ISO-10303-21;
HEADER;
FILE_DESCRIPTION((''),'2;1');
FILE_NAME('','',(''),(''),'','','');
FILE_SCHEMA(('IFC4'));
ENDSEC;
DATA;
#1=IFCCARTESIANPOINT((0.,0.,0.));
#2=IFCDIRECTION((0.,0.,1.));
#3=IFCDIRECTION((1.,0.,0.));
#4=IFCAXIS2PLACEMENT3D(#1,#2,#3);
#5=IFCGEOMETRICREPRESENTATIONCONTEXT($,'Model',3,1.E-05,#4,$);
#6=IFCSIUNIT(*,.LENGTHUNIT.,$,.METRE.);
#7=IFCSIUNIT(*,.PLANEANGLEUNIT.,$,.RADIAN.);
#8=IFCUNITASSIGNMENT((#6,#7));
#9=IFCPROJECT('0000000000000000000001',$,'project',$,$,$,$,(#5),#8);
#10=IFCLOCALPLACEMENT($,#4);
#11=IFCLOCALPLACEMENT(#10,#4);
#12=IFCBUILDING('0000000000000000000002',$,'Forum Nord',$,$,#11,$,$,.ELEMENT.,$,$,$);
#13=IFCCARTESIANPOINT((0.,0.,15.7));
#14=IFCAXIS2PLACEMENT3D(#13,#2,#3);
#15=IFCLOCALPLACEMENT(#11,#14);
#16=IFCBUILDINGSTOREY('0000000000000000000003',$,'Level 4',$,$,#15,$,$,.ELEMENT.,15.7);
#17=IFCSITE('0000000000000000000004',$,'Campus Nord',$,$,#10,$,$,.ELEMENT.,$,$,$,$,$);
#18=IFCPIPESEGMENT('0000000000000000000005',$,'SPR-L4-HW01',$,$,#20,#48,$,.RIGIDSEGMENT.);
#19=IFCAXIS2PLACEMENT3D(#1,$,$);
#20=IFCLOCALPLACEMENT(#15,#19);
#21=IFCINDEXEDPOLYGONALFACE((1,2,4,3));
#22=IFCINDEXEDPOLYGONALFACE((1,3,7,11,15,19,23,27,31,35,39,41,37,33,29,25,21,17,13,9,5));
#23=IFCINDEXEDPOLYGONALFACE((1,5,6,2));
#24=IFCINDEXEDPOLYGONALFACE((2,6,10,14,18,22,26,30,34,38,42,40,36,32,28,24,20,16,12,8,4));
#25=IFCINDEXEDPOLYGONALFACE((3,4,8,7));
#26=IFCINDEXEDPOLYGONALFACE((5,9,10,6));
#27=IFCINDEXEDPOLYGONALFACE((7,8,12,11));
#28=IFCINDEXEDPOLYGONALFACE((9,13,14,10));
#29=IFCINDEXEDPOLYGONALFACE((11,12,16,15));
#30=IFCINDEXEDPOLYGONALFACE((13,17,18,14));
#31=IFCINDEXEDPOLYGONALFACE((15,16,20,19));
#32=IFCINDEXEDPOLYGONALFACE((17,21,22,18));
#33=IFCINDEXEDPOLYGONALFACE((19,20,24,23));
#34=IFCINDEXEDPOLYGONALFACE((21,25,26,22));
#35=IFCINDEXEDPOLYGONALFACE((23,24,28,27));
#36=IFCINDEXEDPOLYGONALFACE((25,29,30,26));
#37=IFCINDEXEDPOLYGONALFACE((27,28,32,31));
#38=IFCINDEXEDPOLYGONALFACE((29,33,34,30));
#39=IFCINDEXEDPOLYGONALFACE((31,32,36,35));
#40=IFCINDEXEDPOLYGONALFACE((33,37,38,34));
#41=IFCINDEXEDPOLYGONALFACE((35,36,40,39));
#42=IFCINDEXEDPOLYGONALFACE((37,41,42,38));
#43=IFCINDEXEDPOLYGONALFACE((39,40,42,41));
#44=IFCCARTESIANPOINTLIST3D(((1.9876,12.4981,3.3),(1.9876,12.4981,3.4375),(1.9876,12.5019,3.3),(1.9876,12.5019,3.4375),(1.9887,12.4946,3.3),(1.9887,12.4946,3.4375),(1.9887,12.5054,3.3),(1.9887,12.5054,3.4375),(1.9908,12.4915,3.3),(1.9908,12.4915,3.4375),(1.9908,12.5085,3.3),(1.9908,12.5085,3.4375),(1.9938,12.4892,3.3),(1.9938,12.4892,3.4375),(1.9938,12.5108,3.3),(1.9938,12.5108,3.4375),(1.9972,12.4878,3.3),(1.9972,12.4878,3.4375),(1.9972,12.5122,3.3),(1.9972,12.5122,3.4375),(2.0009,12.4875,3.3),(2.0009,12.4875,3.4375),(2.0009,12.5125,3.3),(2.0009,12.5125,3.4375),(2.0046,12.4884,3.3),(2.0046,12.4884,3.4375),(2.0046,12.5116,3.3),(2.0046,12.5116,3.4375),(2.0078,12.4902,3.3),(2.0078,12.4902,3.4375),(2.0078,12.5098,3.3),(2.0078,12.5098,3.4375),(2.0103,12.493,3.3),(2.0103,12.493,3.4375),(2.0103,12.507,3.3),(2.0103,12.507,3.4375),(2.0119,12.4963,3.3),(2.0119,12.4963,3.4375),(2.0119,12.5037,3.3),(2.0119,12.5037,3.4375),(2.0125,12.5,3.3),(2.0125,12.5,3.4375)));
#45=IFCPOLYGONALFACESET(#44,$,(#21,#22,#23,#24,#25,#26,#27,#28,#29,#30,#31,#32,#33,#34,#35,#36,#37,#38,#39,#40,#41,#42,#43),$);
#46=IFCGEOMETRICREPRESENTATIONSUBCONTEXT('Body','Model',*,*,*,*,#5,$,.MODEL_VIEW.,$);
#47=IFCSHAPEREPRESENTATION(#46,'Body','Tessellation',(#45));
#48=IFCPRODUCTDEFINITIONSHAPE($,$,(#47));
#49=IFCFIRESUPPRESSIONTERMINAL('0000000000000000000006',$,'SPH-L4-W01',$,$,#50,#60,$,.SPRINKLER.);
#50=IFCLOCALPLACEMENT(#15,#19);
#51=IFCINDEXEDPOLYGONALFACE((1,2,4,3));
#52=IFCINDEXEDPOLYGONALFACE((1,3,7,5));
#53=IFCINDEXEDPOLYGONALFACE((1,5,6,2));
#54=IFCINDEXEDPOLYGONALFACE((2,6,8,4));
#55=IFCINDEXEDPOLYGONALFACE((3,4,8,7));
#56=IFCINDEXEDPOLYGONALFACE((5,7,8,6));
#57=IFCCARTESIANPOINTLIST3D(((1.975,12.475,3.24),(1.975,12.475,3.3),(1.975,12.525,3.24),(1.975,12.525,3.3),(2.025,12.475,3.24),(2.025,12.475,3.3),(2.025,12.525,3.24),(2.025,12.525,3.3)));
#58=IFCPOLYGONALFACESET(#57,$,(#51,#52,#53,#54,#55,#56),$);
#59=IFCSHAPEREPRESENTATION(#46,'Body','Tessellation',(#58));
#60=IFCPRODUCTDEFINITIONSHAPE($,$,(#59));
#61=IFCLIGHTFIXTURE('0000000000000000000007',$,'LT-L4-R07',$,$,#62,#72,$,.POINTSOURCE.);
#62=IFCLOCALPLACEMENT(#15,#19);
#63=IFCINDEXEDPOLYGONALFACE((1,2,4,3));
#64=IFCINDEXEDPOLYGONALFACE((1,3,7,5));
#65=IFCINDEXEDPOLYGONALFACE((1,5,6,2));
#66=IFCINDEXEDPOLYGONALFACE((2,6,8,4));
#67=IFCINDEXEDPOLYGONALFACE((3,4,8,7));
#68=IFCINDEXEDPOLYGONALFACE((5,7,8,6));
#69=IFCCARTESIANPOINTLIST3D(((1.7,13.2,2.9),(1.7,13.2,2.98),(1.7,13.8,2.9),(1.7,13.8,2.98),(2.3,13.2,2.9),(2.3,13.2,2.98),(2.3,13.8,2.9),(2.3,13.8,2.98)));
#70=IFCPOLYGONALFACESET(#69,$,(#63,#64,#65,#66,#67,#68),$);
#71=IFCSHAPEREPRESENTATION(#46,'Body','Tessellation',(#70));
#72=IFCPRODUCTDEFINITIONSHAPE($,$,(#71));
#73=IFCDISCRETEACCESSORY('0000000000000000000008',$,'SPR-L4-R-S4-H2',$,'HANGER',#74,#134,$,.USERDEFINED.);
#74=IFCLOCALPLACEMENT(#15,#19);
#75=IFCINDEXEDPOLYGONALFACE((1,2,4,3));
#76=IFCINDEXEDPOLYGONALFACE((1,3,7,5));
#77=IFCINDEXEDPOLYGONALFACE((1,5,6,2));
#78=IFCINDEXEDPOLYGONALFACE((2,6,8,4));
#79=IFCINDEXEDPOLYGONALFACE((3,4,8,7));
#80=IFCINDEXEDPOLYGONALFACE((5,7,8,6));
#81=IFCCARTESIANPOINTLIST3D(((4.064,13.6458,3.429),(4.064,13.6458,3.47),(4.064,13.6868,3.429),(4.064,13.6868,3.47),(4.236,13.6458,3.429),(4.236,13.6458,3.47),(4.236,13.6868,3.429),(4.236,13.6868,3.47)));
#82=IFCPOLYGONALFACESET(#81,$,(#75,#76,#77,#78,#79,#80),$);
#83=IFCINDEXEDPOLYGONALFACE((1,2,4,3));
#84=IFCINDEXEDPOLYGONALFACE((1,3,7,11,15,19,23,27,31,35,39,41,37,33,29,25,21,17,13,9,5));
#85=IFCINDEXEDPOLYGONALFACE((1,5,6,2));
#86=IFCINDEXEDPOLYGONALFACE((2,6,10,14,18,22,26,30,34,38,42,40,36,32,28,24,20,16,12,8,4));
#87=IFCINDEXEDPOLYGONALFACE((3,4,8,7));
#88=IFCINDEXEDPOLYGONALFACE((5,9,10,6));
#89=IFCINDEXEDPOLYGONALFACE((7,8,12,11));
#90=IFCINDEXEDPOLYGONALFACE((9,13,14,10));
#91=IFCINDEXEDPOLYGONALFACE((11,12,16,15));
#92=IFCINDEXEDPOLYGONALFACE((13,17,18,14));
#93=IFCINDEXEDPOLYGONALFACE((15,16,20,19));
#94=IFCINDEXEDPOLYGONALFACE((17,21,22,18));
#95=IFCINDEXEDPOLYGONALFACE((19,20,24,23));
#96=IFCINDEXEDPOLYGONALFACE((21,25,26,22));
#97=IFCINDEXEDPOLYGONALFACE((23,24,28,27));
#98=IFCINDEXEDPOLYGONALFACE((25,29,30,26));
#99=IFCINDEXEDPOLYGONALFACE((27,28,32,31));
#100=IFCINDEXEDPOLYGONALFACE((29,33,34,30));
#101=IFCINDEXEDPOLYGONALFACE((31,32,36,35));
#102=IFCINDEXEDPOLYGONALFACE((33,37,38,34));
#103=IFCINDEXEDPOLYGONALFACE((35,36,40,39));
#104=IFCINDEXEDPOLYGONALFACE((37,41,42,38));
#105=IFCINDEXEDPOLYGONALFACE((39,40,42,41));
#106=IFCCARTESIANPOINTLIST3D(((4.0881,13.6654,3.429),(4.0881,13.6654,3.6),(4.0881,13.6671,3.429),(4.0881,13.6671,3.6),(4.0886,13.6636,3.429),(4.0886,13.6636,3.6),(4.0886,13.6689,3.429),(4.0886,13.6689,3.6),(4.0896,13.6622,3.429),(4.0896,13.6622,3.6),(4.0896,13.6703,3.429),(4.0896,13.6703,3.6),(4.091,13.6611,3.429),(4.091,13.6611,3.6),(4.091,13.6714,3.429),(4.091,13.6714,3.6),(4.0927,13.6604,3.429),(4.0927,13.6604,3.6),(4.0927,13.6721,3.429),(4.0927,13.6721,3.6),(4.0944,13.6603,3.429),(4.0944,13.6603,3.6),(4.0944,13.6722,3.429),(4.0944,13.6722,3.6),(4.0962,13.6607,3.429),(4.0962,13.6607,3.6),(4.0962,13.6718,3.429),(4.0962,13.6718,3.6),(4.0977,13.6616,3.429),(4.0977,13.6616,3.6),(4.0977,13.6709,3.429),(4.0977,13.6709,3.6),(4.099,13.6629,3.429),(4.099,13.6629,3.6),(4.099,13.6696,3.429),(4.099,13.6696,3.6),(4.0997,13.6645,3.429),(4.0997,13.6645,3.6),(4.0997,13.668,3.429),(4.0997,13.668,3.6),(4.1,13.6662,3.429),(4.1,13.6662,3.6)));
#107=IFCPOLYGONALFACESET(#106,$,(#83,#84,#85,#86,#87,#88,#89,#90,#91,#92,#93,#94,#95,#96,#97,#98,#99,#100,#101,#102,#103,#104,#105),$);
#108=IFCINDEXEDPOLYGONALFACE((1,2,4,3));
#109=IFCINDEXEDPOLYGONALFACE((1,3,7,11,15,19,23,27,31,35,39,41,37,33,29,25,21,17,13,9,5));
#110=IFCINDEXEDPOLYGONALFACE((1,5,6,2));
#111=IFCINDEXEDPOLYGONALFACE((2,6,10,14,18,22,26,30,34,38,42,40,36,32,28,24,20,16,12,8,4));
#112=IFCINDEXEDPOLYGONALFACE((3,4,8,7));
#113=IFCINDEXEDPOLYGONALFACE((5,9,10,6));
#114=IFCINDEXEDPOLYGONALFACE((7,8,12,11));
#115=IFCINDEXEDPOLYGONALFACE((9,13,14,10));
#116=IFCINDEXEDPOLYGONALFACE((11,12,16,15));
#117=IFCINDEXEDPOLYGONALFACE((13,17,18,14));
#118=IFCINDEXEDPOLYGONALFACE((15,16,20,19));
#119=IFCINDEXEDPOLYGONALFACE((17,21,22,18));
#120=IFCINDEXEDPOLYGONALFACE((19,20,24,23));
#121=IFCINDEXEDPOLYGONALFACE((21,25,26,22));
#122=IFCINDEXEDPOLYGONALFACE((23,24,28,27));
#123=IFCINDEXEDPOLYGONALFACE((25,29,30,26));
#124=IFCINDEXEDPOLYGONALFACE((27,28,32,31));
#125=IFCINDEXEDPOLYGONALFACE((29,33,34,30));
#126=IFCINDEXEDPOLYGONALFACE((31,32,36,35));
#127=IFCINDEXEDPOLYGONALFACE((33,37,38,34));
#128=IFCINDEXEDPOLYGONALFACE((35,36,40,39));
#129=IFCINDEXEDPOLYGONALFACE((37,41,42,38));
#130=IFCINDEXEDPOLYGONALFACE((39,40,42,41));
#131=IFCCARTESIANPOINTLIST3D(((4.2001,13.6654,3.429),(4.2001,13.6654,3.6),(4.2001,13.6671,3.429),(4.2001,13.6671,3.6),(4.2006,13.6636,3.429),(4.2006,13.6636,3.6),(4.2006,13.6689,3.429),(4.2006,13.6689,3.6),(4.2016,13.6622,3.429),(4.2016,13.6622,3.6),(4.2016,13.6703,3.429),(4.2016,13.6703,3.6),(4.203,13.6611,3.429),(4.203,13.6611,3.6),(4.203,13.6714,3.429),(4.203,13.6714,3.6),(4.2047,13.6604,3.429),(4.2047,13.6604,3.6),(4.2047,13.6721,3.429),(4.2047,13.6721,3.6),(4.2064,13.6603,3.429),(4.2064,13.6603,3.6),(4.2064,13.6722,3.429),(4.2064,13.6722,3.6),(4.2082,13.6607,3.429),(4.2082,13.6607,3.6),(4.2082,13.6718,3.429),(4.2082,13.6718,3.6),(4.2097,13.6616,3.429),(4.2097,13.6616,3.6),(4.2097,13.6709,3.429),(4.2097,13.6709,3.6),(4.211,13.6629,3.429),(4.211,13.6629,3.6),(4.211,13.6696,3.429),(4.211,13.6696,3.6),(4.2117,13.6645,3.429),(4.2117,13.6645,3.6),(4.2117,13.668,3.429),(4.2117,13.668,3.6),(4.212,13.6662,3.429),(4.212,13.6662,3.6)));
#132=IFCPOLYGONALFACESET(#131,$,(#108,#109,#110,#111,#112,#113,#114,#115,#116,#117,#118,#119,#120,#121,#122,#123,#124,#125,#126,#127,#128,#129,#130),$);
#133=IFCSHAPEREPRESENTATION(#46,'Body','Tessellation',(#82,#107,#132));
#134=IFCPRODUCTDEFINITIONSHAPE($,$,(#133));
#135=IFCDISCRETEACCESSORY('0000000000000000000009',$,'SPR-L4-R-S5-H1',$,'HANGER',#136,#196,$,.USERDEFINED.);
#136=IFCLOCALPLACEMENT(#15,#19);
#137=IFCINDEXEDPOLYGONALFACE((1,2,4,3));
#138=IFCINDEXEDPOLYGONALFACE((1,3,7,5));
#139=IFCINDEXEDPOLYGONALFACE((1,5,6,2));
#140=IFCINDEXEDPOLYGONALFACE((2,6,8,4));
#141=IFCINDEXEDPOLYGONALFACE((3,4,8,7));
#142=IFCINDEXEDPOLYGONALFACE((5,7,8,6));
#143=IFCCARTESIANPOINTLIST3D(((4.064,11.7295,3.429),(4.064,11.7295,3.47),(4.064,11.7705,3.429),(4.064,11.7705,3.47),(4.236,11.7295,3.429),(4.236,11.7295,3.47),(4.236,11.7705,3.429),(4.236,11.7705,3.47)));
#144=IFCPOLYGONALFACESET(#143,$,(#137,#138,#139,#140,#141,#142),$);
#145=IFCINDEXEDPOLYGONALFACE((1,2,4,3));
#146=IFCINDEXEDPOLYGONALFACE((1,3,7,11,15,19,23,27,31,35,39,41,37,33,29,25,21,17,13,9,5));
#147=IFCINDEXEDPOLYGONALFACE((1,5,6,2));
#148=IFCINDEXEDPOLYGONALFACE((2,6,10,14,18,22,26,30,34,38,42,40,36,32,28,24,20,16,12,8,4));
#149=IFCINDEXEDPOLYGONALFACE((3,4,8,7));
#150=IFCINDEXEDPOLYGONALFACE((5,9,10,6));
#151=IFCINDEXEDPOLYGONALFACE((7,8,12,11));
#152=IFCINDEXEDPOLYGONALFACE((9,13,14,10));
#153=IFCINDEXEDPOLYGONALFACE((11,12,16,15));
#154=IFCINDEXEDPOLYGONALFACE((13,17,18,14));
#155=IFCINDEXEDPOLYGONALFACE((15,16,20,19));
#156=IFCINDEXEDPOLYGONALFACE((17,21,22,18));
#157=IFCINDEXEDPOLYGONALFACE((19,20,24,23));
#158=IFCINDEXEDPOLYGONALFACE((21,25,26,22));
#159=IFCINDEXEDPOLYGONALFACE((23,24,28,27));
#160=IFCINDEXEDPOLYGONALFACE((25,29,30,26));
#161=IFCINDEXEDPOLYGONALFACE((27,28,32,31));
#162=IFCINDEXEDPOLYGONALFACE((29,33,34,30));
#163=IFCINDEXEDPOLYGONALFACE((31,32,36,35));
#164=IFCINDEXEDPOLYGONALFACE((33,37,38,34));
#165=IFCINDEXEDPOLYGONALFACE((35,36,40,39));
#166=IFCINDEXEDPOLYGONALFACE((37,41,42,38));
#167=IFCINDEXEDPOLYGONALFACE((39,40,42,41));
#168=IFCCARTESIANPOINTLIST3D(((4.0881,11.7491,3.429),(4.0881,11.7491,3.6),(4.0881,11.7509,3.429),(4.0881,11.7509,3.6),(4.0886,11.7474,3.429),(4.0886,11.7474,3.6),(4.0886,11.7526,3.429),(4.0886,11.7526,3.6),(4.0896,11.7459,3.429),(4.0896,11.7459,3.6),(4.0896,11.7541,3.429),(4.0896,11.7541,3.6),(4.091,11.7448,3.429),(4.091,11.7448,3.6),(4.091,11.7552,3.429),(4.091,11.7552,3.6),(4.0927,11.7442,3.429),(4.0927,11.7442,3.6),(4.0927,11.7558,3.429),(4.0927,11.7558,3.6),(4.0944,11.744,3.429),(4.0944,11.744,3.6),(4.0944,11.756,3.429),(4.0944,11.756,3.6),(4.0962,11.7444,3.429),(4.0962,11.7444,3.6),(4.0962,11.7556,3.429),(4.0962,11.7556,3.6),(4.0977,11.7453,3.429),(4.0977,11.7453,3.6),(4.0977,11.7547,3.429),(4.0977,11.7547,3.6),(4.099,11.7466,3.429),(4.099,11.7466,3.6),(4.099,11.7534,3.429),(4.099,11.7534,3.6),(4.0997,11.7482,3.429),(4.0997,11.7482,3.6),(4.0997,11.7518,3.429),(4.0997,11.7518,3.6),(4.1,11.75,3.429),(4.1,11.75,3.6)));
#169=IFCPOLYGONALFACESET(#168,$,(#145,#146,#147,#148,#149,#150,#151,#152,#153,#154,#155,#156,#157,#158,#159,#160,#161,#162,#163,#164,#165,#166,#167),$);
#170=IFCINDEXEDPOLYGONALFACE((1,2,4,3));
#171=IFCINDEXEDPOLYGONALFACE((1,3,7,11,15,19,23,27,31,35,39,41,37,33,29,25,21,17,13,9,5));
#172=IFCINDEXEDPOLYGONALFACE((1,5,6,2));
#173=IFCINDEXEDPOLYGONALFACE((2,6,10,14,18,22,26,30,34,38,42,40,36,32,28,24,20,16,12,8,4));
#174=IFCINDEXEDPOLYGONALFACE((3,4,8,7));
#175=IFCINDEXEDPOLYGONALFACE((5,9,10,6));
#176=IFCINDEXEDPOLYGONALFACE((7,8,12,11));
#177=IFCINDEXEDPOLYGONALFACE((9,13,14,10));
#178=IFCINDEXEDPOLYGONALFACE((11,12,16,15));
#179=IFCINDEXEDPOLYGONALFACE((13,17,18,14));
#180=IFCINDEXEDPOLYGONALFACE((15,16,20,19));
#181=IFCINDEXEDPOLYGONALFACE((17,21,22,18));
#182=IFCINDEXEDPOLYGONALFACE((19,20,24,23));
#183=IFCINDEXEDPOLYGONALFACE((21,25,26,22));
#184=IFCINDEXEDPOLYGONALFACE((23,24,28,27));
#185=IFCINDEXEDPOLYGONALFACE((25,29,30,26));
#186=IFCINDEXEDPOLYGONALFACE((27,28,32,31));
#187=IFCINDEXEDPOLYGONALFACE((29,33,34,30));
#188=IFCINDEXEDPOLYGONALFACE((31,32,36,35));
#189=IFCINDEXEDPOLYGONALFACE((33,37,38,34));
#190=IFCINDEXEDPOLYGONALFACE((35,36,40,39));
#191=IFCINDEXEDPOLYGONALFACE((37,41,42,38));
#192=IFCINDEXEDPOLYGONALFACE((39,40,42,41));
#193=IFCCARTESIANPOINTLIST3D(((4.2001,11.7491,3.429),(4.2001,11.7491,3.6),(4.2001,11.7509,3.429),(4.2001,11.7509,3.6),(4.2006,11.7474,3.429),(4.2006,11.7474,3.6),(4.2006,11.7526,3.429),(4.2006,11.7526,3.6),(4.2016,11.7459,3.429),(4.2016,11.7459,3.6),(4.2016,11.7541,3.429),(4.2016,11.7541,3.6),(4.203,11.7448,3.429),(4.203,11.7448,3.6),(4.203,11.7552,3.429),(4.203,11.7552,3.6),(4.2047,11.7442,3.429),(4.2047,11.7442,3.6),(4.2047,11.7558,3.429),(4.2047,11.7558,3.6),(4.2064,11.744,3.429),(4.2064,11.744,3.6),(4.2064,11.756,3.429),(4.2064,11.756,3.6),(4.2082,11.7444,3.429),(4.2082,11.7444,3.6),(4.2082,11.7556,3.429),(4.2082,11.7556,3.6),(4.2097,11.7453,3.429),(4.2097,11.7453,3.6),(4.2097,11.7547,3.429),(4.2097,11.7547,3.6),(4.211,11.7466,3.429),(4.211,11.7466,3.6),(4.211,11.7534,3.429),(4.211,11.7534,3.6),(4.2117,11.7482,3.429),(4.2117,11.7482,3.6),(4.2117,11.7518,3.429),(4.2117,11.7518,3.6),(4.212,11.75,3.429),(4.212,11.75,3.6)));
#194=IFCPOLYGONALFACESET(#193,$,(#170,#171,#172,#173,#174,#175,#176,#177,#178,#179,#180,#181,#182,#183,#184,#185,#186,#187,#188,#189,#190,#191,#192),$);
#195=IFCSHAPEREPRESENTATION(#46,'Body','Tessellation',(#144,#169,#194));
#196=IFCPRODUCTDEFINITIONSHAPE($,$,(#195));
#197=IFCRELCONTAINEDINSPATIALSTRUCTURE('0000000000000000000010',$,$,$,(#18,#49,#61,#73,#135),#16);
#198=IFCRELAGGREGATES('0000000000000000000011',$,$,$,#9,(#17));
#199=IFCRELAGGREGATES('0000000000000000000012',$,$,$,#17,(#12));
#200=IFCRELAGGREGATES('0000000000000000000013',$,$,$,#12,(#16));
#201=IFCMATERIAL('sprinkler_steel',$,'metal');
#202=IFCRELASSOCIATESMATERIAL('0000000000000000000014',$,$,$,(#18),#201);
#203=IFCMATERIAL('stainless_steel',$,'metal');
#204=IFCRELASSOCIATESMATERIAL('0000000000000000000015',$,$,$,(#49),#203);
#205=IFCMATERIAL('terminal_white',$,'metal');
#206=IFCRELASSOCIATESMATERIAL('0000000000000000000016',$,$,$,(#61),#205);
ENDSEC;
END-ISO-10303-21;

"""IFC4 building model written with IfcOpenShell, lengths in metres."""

from ifc_helpers import new_model, si_unit, frame, frame_2d, origin_with_axes, origin_2d_with_axis, place, context, subcontext, project, spatial, rectangle, circle, extrude, material, element, save


model = new_model("IFC4")

# Units and contexts
model_context = context("Model", 3, precision=1e-05, world=origin_with_axes())
body_context = subcontext(model_context, "Body", "Model", "MODEL_VIEW")
ifc_project = project(units=[si_unit("LENGTHUNIT", "METRE"), si_unit("PLANEANGLEUNIT", "RADIAN")], contexts=[model_context])

# Site, building, storey
site_placement = place(None, origin_with_axes())
site = spatial("IfcSite", under=ifc_project, at=site_placement, Name="Campus Nord", CompositionType="ELEMENT")
building_placement = place(site_placement, origin_with_axes())
building = spatial("IfcBuilding", under=site, at=building_placement, Name="Forum Nord", CompositionType="ELEMENT")
storey_placement = place(building_placement, frame((0.0, 0.0, 15.7), z_axis=(0.0, 0.0, 1.0), x_axis=(1.0, 0.0, 0.0)))
storey = spatial("IfcBuildingStorey", under=building, at=storey_placement, Name="Level 4", CompositionType="ELEMENT", Elevation=15.7)

# Shared definitions
ifc_material_1 = material(Name="sprinkler_steel", Category="metal")

# Pipe segment
pipe_segment_1_placement = place(storey_placement, frame((2.0, 12.5, 3.4375), z_axis=(0.0, 0.0, -1.0), x_axis=(1.0, 0.0, 0.0)))
element("IfcPipeSegment", 1, at=pipe_segment_1_placement, inside=storey, material=ifc_material_1, Name="SPR-L4-HW01", PredefinedType="RIGIDSEGMENT", context=body_context, shape_type="SweptSolid", body=[
    extrude(circle(Radius=0.0125, at=origin_2d_with_axis()), origin_with_axes(), (0.0, 0.0, 1.0), 0.1375),
])

# Fire suppression terminal
ifc_material_2 = material(Name="stainless_steel", Category="metal")
fire_suppression_terminal_placement = place(storey_placement, frame((2.0, 12.5, 3.24), z_axis=(0.0, 0.0, 1.0), x_axis=(1.0, 0.0, 0.0)))
element("IfcFireSuppressionTerminal", 2, at=fire_suppression_terminal_placement, inside=storey, material=ifc_material_2, Name="SPH-L4-W01", PredefinedType="SPRINKLER", context=body_context, shape_type="SweptSolid", body=[
    extrude(rectangle(XDim=0.05, YDim=0.05, at=origin_2d_with_axis()), origin_with_axes(), (0.0, 0.0, 1.0), 0.06),
])

# Light fixture
ifc_material_3 = material(Name="terminal_white", Category="metal")
light_fixture_placement = place(storey_placement, frame((2.0, 13.5, 2.9), z_axis=(0.0, 0.0, 1.0), x_axis=(1.0, 0.0, 0.0)))
element("IfcLightFixture", 3, at=light_fixture_placement, inside=storey, material=ifc_material_3, Name="LT-L4-R07", PredefinedType="POINTSOURCE", context=body_context, shape_type="SweptSolid", body=[
    extrude(rectangle(XDim=0.6, YDim=0.6, at=origin_2d_with_axis()), origin_with_axes(), (0.0, 0.0, 1.0), 0.08),
])

# Discrete accessories
for number, where, z_axis, x_axis, name in (
    (4, (4.15, 13.6662, 3.47), (0.0, 0.0, 1.0), (1.0, 0.0, 0.0), "SPR-L4-R-S4-H2"),
    (5, (4.15, 11.75, 3.47), (0.0, 0.0, 1.0), (1.0, 0.0, 0.0), "SPR-L4-R-S5-H1"),
):
    element("IfcDiscreteAccessory", number, at=place(storey_placement, frame(where, z_axis=z_axis, x_axis=x_axis)), inside=storey, Name=name, ObjectType="HANGER", PredefinedType="USERDEFINED", context=body_context, shape_type="SweptSolid", body=[
        extrude(rectangle(XDim=0.172, YDim=0.041, at=origin_2d_with_axis()), frame((0.0, 0.0, -0.041), z_axis=(0.0, 0.0, 1.0), x_axis=(1.0, 0.0, 0.0)), (0.0, 0.0, 1.0), 0.041),
        extrude(circle(Radius=0.006, at=frame_2d((-0.056, 0.0), x_axis=(1.0, 0.0))), frame((0.0, 0.0, -0.041), z_axis=(0.0, 0.0, 1.0), x_axis=(1.0, 0.0, 0.0)), (0.0, 0.0, 1.0), 0.171),
        extrude(circle(Radius=0.006, at=frame_2d((0.056, 0.0), x_axis=(1.0, 0.0))), frame((0.0, 0.0, -0.041), z_axis=(0.0, 0.0, 1.0), x_axis=(1.0, 0.0, 0.0)), (0.0, 0.0, 1.0), 0.171),
    ])

save(model, "model.ifc")
